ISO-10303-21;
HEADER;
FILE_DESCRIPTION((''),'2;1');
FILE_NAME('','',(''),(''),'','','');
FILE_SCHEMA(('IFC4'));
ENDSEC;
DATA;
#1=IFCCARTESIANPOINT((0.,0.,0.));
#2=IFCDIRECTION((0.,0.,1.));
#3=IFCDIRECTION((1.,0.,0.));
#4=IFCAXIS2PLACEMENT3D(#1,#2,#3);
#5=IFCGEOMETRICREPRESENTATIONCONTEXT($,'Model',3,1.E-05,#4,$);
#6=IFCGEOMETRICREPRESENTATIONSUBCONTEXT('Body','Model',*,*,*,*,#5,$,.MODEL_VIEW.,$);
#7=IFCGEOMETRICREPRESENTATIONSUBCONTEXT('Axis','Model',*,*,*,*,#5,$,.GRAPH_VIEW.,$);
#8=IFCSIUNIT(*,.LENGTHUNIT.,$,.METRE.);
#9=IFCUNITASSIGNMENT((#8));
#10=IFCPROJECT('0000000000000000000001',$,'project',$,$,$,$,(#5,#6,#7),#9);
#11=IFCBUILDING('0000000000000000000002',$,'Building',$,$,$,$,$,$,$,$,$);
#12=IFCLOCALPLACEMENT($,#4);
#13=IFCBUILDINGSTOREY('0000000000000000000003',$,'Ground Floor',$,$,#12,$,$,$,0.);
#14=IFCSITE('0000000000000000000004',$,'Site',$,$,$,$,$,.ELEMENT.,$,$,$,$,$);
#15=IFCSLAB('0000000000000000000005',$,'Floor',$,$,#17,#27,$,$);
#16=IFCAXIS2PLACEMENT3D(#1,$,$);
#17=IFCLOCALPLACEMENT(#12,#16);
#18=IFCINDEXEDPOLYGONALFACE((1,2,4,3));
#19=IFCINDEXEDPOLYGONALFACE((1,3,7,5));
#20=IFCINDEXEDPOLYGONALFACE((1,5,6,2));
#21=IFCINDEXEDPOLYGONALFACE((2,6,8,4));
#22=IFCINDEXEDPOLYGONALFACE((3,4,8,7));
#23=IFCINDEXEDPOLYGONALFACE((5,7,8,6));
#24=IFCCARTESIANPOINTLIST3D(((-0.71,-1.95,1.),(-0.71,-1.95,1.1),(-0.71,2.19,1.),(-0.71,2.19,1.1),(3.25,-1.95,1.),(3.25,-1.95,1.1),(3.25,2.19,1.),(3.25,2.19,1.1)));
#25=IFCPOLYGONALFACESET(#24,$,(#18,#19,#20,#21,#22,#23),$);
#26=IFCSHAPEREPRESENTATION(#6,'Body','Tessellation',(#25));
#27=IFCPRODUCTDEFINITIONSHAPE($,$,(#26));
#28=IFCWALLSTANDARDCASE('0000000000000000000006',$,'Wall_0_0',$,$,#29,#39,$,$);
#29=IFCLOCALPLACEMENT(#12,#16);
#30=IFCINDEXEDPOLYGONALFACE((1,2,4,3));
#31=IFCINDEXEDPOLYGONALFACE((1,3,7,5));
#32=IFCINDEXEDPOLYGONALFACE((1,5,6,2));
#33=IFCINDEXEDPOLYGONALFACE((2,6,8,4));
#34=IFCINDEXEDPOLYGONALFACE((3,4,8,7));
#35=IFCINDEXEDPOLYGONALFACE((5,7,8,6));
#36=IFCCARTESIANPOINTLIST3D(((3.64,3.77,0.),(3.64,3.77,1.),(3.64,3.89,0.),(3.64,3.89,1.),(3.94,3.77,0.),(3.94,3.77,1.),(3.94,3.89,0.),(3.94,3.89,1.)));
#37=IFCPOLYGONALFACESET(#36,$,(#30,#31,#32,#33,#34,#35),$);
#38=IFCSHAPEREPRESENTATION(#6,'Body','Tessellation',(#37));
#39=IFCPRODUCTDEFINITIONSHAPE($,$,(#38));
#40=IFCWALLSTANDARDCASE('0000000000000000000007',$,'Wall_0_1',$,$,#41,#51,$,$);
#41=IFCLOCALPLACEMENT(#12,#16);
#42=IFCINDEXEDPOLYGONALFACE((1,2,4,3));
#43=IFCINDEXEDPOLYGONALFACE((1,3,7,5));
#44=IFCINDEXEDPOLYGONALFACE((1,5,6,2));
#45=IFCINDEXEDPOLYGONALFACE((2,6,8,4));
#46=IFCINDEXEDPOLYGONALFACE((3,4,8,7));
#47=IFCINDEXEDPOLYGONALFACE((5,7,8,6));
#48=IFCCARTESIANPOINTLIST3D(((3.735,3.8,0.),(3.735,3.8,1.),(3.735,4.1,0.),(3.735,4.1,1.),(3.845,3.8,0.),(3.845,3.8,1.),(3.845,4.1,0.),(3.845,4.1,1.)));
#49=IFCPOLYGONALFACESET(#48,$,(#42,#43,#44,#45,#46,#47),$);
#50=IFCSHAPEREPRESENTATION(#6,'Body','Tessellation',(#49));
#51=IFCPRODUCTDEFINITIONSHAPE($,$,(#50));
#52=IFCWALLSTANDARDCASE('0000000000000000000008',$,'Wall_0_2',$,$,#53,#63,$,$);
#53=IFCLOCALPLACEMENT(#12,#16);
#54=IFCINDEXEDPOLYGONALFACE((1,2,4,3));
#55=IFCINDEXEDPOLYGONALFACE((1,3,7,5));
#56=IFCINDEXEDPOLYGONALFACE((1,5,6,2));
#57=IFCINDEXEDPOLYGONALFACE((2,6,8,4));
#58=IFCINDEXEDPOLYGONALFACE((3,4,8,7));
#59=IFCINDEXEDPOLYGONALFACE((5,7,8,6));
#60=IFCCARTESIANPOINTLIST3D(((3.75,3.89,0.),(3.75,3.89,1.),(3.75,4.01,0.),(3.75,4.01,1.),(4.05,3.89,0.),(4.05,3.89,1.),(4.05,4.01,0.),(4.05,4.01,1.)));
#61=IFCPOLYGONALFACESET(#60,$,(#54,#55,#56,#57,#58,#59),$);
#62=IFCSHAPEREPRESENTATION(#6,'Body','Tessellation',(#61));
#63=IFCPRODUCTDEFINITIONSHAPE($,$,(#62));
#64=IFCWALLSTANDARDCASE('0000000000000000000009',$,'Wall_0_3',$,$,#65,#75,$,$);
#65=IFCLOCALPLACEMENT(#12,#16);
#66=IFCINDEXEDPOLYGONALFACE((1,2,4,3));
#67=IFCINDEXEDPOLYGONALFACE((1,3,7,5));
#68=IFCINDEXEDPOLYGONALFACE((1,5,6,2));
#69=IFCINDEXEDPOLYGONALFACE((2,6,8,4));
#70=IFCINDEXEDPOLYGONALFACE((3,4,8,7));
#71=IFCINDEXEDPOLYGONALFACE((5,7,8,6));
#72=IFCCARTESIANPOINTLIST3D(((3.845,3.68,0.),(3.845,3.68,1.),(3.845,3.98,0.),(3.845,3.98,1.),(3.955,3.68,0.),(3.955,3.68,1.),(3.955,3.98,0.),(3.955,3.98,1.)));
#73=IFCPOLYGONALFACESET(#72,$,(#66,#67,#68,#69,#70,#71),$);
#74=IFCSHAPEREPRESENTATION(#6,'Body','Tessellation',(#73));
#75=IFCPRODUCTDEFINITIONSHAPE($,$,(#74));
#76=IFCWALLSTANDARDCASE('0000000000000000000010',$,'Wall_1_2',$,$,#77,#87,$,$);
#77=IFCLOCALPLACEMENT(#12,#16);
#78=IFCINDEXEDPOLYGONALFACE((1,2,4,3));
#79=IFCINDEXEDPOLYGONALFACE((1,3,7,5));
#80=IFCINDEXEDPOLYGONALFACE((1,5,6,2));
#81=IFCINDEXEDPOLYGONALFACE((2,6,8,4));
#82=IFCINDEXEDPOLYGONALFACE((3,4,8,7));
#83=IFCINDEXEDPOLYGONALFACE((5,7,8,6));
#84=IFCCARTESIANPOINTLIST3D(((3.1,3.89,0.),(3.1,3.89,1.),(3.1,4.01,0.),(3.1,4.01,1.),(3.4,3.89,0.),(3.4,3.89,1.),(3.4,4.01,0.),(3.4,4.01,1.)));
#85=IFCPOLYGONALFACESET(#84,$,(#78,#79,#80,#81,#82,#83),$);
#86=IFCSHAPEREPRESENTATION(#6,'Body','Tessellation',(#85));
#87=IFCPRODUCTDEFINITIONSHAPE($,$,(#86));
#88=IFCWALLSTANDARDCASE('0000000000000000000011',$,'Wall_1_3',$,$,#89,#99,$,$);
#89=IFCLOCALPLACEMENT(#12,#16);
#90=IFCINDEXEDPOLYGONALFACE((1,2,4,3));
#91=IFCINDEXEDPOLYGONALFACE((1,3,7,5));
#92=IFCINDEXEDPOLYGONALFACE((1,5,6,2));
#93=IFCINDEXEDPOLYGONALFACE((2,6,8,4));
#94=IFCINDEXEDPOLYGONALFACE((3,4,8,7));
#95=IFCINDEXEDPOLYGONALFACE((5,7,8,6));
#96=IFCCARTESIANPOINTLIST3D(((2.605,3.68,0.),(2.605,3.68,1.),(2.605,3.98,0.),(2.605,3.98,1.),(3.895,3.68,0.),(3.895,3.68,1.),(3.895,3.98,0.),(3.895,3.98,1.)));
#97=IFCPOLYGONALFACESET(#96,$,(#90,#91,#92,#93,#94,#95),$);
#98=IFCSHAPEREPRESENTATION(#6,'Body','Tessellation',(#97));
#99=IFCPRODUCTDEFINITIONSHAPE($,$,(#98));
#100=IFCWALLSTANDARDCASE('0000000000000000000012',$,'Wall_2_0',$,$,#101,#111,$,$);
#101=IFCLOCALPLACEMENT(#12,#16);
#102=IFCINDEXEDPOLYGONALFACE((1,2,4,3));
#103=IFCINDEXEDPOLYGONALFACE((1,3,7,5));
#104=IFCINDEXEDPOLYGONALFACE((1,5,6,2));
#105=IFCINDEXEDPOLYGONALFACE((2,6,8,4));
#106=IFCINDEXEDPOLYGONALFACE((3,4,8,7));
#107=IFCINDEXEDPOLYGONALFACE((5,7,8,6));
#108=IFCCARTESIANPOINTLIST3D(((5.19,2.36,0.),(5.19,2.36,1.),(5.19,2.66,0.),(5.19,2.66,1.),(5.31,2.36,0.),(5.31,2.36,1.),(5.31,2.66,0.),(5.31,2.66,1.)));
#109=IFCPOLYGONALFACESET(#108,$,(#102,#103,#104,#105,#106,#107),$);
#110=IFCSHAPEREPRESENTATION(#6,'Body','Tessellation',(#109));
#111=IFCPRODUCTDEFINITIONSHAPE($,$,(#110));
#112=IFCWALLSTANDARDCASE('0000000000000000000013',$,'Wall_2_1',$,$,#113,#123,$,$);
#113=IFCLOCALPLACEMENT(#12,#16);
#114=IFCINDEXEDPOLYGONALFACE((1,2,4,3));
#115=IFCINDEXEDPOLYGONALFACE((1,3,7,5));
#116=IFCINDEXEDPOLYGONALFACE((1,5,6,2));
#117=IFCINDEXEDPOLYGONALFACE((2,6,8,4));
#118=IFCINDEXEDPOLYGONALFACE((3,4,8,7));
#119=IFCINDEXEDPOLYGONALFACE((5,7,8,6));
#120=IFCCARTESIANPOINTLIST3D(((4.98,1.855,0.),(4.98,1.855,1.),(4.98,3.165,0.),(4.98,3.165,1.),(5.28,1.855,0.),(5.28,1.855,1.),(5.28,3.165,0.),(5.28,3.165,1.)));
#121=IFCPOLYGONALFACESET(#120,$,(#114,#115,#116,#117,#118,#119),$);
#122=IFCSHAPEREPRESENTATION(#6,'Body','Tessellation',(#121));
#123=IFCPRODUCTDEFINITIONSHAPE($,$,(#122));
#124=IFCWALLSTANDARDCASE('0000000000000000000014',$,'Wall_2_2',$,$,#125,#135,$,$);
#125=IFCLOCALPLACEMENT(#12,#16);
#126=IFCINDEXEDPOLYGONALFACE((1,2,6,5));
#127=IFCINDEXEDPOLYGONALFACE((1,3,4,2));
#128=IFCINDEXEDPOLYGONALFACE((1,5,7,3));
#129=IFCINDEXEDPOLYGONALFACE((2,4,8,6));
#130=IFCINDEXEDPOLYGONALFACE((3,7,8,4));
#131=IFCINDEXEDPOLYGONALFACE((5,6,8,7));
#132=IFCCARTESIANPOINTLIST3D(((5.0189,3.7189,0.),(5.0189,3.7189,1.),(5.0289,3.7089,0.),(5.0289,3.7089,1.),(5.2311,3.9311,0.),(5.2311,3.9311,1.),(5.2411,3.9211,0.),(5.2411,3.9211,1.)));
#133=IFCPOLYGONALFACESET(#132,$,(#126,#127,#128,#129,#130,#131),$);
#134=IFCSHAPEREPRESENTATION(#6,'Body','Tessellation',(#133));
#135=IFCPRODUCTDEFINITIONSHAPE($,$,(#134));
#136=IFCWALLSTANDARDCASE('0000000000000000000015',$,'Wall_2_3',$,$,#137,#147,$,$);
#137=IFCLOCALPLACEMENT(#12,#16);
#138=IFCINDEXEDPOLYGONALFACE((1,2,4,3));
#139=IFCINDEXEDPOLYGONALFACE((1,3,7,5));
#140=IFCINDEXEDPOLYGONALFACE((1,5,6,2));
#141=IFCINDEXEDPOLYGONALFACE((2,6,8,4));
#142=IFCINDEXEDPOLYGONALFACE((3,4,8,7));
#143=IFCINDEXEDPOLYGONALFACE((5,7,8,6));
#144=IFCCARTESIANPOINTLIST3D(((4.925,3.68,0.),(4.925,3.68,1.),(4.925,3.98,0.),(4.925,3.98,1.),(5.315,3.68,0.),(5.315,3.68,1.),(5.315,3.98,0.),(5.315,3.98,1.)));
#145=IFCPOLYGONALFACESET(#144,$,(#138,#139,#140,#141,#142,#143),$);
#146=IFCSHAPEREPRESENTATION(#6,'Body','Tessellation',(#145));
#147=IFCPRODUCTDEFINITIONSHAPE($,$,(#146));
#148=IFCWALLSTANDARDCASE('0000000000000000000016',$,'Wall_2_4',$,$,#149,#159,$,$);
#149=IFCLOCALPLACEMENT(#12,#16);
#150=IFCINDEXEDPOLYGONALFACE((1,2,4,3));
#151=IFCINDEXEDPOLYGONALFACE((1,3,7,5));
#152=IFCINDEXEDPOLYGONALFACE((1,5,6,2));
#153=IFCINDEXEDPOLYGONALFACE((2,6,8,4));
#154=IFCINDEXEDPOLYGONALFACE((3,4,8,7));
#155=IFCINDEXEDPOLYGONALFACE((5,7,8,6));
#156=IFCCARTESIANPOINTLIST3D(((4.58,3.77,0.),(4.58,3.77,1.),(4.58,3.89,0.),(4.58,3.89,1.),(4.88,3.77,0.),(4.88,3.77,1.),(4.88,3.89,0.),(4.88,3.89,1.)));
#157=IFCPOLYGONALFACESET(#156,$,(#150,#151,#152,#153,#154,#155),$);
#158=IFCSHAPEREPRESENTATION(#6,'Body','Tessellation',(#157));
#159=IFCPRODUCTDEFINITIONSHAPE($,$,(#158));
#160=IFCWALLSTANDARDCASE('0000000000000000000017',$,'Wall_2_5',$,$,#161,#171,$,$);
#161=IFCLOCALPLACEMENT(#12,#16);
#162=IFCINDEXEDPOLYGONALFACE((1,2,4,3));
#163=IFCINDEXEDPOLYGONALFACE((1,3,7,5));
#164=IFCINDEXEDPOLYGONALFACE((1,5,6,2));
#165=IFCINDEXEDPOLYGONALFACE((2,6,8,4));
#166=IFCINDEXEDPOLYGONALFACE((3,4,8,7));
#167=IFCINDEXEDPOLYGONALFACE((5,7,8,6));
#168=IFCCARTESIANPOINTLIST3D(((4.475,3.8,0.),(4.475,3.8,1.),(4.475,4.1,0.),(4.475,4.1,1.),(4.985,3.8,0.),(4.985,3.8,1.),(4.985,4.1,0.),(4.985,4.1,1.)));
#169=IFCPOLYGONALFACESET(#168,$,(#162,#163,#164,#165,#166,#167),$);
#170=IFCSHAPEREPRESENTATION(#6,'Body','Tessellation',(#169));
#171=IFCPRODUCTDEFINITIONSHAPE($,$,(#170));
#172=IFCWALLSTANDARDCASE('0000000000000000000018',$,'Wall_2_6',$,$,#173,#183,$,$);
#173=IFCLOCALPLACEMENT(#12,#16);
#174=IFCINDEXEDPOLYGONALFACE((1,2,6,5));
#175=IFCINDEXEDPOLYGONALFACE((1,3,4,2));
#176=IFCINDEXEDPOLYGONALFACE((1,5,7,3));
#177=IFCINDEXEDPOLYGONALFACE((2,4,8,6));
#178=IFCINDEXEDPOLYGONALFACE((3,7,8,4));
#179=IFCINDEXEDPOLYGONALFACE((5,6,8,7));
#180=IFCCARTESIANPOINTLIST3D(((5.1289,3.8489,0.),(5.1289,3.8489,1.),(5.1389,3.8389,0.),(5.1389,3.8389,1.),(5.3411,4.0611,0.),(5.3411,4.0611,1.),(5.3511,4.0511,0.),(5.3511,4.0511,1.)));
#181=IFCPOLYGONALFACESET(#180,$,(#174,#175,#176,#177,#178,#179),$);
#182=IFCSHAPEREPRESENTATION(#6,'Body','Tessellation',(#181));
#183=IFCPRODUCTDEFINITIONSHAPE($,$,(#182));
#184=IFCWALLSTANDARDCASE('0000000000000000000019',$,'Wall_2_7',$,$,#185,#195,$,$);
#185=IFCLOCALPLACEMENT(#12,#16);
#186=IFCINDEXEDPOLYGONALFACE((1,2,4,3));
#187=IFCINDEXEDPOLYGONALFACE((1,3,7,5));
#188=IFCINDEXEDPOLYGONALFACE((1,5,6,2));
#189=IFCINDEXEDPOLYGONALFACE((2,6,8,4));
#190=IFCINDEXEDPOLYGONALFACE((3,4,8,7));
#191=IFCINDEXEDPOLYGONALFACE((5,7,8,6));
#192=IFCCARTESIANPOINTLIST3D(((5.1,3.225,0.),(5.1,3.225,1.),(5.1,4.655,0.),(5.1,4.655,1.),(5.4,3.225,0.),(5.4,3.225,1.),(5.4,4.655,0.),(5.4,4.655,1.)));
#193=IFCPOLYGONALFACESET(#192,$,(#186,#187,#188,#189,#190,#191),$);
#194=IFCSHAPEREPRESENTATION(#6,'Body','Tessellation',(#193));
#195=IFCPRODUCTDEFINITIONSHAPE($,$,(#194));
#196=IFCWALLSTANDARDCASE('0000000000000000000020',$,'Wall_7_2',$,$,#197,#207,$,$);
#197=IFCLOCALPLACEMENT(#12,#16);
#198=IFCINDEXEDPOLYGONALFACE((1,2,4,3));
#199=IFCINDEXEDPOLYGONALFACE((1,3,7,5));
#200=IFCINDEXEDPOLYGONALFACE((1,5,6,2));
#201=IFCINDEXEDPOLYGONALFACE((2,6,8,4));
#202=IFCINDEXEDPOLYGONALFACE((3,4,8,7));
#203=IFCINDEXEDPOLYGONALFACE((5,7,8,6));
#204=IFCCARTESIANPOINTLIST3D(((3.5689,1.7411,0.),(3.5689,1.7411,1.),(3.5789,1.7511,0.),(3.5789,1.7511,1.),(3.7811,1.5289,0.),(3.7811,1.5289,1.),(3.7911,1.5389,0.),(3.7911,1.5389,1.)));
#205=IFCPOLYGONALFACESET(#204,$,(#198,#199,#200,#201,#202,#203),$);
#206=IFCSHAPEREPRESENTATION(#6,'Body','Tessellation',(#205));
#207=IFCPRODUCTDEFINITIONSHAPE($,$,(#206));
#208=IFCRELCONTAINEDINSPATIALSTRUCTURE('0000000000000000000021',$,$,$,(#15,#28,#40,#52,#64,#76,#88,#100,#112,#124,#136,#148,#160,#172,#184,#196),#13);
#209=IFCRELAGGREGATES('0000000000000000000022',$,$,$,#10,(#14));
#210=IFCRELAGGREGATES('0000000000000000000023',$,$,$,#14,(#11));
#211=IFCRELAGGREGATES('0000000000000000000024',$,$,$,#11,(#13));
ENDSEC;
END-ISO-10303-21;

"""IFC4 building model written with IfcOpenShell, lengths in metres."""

from ifc_helpers import new_model, si_unit, frame, frame_2d, origin_with_axes, origin_2d, place, context, subcontext, project, spatial, rectangle, extrude, element, save


model = new_model("IFC4")

# Units and contexts
model_context = context("Model", 3, precision=1e-05, world=origin_with_axes())
body_context = subcontext(model_context, "Body", "Model", "MODEL_VIEW")
axis_context = subcontext(model_context, "Axis", "Model", "GRAPH_VIEW")
ifc_project = project(units=[si_unit("LENGTHUNIT", "METRE")], contexts=[model_context, body_context, axis_context])

# Site, building, storey
site = spatial("IfcSite", under=ifc_project, Name="Site", CompositionType="ELEMENT")
building = spatial("IfcBuilding", under=site, Name="Building")
storey_placement = place(None, origin_with_axes())
storey = spatial("IfcBuildingStorey", under=building, at=storey_placement, Name="Ground Floor", Elevation=0.0)

# Slab
slab_placement = place(storey_placement, frame((3.25, 2.19, 1.0), z_axis=(0.0, 0.0, 1.0), x_axis=(1.0, 0.0, 0.0)))
element("IfcSlab", 1, at=slab_placement, inside=storey, Name="Floor", context=body_context, shape_type="SweptSolid", body=[
    extrude(rectangle(XDim=3.96, YDim=4.14, at=frame_2d((-1.98, -2.07))), origin_with_axes(), (0.0, 0.0, 1.0), 0.1),
])

# Walls
wall_1_placement = place(storey_placement, frame((3.79, 3.83, 0.0), z_axis=(0.0, 0.0, 1.0), x_axis=(0.0, 1.0, 0.0)))
element("IfcWallStandardCase", 2, at=wall_1_placement, inside=storey, Name="Wall_0_0", context=body_context, shape_type="SweptSolid", body=[
    extrude(rectangle(XDim=0.12, YDim=0.3, at=origin_2d()), origin_with_axes(), (0.0, 0.0, 1.0), 1.0),
])
wall_2_placement = place(storey_placement, frame((3.79, 3.95, 0.0), z_axis=(0.0, 0.0, 1.0), x_axis=(1.0, 0.0, 0.0)))
element("IfcWallStandardCase", 3, at=wall_2_placement, inside=storey, Name="Wall_0_1", context=body_context, shape_type="SweptSolid", body=[
    extrude(rectangle(XDim=0.11, YDim=0.3, at=origin_2d()), origin_with_axes(), (0.0, 0.0, 1.0), 1.0),
])
wall_3_placement = place(storey_placement, frame((3.9, 3.95, 0.0), z_axis=(0.0, 0.0, 1.0), x_axis=(0.0, -1.0, 0.0)))
element("IfcWallStandardCase", 4, at=wall_3_placement, inside=storey, Name="Wall_0_2", context=body_context, shape_type="SweptSolid", body=[
    extrude(rectangle(XDim=0.12, YDim=0.3, at=origin_2d()), origin_with_axes(), (0.0, 0.0, 1.0), 1.0),
])
wall_4_placement = place(storey_placement, frame((3.9, 3.83, 0.0), z_axis=(0.0, 0.0, 1.0), x_axis=(-1.0, 0.0, 0.0)))
element("IfcWallStandardCase", 5, at=wall_4_placement, inside=storey, Name="Wall_0_3", context=body_context, shape_type="SweptSolid", body=[
    extrude(rectangle(XDim=0.11, YDim=0.3, at=origin_2d()), origin_with_axes(), (0.0, 0.0, 1.0), 1.0),
])
wall_5_placement = place(storey_placement, frame((3.25, 3.95, 0.0), z_axis=(0.0, 0.0, 1.0), x_axis=(0.0, -1.0, 0.0)))
element("IfcWallStandardCase", 6, at=wall_5_placement, inside=storey, Name="Wall_1_2", context=body_context, shape_type="SweptSolid", body=[
    extrude(rectangle(XDim=0.12, YDim=0.3, at=origin_2d()), origin_with_axes(), (0.0, 0.0, 1.0), 1.0),
])
wall_6_placement = place(storey_placement, frame((3.25, 3.83, 0.0), z_axis=(0.0, 0.0, 1.0), x_axis=(-1.0, 0.0, 0.0)))
element("IfcWallStandardCase", 7, at=wall_6_placement, inside=storey, Name="Wall_1_3", context=body_context, shape_type="SweptSolid", body=[
    extrude(rectangle(XDim=1.29, YDim=0.3, at=origin_2d()), origin_with_axes(), (0.0, 0.0, 1.0), 1.0),
])
wall_7_placement = place(storey_placement, frame((5.25, 2.51, 0.0), z_axis=(0.0, 0.0, 1.0), x_axis=(-1.0, 0.0, 0.0)))
element("IfcWallStandardCase", 8, at=wall_7_placement, inside=storey, Name="Wall_2_0", context=body_context, shape_type="SweptSolid", body=[
    extrude(rectangle(XDim=0.12, YDim=0.3, at=origin_2d()), origin_with_axes(), (0.0, 0.0, 1.0), 1.0),
])
wall_8_placement = place(storey_placement, frame((5.13, 2.51, 0.0), z_axis=(0.0, 0.0, 1.0), x_axis=(0.0, 1.0, 0.0)))
element("IfcWallStandardCase", 9, at=wall_8_placement, inside=storey, Name="Wall_2_1", context=body_context, shape_type="SweptSolid", body=[
    extrude(rectangle(XDim=1.31, YDim=0.3, at=origin_2d()), origin_with_axes(), (0.0, 0.0, 1.0), 1.0),
])
wall_9_placement = place(storey_placement, frame((5.13, 3.82, 0.0), z_axis=(0.0, 0.0, 1.0), x_axis=(-0.707107, 0.707107, 0.0)))
element("IfcWallStandardCase", 10, at=wall_9_placement, inside=storey, Name="Wall_2_2", context=body_context, shape_type="SweptSolid", body=[
    extrude(rectangle(XDim=0.0141, YDim=0.3, at=origin_2d()), origin_with_axes(), (0.0, 0.0, 1.0), 1.0),
])
wall_10_placement = place(storey_placement, frame((5.12, 3.83, 0.0), z_axis=(0.0, 0.0, 1.0), x_axis=(-1.0, 0.0, 0.0)))
element("IfcWallStandardCase", 11, at=wall_10_placement, inside=storey, Name="Wall_2_3", context=body_context, shape_type="SweptSolid", body=[
    extrude(rectangle(XDim=0.39, YDim=0.3, at=origin_2d()), origin_with_axes(), (0.0, 0.0, 1.0), 1.0),
])
wall_11_placement = place(storey_placement, frame((4.73, 3.83, 0.0), z_axis=(0.0, 0.0, 1.0), x_axis=(0.0, 1.0, 0.0)))
element("IfcWallStandardCase", 12, at=wall_11_placement, inside=storey, Name="Wall_2_4", context=body_context, shape_type="SweptSolid", body=[
    extrude(rectangle(XDim=0.12, YDim=0.3, at=origin_2d()), origin_with_axes(), (0.0, 0.0, 1.0), 1.0),
])
wall_12_placement = place(storey_placement, frame((4.73, 3.95, 0.0), z_axis=(0.0, 0.0, 1.0), x_axis=(1.0, 0.0, 0.0)))
element("IfcWallStandardCase", 13, at=wall_12_placement, inside=storey, Name="Wall_2_5", context=body_context, shape_type="SweptSolid", body=[
    extrude(rectangle(XDim=0.51, YDim=0.3, at=origin_2d()), origin_with_axes(), (0.0, 0.0, 1.0), 1.0),
])
wall_13_placement = place(storey_placement, frame((5.24, 3.95, 0.0), z_axis=(0.0, 0.0, 1.0), x_axis=(0.707107, -0.707107, 0.0)))
element("IfcWallStandardCase", 14, at=wall_13_placement, inside=storey, Name="Wall_2_6", context=body_context, shape_type="SweptSolid", body=[
    extrude(rectangle(XDim=0.0141, YDim=0.3, at=origin_2d()), origin_with_axes(), (0.0, 0.0, 1.0), 1.0),
])
wall_14_placement = place(storey_placement, frame((5.25, 3.94, 0.0), z_axis=(0.0, 0.0, 1.0), x_axis=(0.0, -1.0, 0.0)))
element("IfcWallStandardCase", 15, at=wall_14_placement, inside=storey, Name="Wall_2_7", context=body_context, shape_type="SweptSolid", body=[
    extrude(rectangle(XDim=1.43, YDim=0.3, at=origin_2d()), origin_with_axes(), (0.0, 0.0, 1.0), 1.0),
])
wall_15_placement = place(storey_placement, frame((3.68, 1.64, 0.0), z_axis=(0.0, 0.0, 1.0), x_axis=(0.707107, 0.707107, 0.0)))
element("IfcWallStandardCase", 16, at=wall_15_placement, inside=storey, Name="Wall_7_2", context=body_context, shape_type="SweptSolid", body=[
    extrude(rectangle(XDim=0.0141, YDim=0.3, at=origin_2d()), origin_with_axes(), (0.0, 0.0, 1.0), 1.0),
])

save(model, "model.ifc")
